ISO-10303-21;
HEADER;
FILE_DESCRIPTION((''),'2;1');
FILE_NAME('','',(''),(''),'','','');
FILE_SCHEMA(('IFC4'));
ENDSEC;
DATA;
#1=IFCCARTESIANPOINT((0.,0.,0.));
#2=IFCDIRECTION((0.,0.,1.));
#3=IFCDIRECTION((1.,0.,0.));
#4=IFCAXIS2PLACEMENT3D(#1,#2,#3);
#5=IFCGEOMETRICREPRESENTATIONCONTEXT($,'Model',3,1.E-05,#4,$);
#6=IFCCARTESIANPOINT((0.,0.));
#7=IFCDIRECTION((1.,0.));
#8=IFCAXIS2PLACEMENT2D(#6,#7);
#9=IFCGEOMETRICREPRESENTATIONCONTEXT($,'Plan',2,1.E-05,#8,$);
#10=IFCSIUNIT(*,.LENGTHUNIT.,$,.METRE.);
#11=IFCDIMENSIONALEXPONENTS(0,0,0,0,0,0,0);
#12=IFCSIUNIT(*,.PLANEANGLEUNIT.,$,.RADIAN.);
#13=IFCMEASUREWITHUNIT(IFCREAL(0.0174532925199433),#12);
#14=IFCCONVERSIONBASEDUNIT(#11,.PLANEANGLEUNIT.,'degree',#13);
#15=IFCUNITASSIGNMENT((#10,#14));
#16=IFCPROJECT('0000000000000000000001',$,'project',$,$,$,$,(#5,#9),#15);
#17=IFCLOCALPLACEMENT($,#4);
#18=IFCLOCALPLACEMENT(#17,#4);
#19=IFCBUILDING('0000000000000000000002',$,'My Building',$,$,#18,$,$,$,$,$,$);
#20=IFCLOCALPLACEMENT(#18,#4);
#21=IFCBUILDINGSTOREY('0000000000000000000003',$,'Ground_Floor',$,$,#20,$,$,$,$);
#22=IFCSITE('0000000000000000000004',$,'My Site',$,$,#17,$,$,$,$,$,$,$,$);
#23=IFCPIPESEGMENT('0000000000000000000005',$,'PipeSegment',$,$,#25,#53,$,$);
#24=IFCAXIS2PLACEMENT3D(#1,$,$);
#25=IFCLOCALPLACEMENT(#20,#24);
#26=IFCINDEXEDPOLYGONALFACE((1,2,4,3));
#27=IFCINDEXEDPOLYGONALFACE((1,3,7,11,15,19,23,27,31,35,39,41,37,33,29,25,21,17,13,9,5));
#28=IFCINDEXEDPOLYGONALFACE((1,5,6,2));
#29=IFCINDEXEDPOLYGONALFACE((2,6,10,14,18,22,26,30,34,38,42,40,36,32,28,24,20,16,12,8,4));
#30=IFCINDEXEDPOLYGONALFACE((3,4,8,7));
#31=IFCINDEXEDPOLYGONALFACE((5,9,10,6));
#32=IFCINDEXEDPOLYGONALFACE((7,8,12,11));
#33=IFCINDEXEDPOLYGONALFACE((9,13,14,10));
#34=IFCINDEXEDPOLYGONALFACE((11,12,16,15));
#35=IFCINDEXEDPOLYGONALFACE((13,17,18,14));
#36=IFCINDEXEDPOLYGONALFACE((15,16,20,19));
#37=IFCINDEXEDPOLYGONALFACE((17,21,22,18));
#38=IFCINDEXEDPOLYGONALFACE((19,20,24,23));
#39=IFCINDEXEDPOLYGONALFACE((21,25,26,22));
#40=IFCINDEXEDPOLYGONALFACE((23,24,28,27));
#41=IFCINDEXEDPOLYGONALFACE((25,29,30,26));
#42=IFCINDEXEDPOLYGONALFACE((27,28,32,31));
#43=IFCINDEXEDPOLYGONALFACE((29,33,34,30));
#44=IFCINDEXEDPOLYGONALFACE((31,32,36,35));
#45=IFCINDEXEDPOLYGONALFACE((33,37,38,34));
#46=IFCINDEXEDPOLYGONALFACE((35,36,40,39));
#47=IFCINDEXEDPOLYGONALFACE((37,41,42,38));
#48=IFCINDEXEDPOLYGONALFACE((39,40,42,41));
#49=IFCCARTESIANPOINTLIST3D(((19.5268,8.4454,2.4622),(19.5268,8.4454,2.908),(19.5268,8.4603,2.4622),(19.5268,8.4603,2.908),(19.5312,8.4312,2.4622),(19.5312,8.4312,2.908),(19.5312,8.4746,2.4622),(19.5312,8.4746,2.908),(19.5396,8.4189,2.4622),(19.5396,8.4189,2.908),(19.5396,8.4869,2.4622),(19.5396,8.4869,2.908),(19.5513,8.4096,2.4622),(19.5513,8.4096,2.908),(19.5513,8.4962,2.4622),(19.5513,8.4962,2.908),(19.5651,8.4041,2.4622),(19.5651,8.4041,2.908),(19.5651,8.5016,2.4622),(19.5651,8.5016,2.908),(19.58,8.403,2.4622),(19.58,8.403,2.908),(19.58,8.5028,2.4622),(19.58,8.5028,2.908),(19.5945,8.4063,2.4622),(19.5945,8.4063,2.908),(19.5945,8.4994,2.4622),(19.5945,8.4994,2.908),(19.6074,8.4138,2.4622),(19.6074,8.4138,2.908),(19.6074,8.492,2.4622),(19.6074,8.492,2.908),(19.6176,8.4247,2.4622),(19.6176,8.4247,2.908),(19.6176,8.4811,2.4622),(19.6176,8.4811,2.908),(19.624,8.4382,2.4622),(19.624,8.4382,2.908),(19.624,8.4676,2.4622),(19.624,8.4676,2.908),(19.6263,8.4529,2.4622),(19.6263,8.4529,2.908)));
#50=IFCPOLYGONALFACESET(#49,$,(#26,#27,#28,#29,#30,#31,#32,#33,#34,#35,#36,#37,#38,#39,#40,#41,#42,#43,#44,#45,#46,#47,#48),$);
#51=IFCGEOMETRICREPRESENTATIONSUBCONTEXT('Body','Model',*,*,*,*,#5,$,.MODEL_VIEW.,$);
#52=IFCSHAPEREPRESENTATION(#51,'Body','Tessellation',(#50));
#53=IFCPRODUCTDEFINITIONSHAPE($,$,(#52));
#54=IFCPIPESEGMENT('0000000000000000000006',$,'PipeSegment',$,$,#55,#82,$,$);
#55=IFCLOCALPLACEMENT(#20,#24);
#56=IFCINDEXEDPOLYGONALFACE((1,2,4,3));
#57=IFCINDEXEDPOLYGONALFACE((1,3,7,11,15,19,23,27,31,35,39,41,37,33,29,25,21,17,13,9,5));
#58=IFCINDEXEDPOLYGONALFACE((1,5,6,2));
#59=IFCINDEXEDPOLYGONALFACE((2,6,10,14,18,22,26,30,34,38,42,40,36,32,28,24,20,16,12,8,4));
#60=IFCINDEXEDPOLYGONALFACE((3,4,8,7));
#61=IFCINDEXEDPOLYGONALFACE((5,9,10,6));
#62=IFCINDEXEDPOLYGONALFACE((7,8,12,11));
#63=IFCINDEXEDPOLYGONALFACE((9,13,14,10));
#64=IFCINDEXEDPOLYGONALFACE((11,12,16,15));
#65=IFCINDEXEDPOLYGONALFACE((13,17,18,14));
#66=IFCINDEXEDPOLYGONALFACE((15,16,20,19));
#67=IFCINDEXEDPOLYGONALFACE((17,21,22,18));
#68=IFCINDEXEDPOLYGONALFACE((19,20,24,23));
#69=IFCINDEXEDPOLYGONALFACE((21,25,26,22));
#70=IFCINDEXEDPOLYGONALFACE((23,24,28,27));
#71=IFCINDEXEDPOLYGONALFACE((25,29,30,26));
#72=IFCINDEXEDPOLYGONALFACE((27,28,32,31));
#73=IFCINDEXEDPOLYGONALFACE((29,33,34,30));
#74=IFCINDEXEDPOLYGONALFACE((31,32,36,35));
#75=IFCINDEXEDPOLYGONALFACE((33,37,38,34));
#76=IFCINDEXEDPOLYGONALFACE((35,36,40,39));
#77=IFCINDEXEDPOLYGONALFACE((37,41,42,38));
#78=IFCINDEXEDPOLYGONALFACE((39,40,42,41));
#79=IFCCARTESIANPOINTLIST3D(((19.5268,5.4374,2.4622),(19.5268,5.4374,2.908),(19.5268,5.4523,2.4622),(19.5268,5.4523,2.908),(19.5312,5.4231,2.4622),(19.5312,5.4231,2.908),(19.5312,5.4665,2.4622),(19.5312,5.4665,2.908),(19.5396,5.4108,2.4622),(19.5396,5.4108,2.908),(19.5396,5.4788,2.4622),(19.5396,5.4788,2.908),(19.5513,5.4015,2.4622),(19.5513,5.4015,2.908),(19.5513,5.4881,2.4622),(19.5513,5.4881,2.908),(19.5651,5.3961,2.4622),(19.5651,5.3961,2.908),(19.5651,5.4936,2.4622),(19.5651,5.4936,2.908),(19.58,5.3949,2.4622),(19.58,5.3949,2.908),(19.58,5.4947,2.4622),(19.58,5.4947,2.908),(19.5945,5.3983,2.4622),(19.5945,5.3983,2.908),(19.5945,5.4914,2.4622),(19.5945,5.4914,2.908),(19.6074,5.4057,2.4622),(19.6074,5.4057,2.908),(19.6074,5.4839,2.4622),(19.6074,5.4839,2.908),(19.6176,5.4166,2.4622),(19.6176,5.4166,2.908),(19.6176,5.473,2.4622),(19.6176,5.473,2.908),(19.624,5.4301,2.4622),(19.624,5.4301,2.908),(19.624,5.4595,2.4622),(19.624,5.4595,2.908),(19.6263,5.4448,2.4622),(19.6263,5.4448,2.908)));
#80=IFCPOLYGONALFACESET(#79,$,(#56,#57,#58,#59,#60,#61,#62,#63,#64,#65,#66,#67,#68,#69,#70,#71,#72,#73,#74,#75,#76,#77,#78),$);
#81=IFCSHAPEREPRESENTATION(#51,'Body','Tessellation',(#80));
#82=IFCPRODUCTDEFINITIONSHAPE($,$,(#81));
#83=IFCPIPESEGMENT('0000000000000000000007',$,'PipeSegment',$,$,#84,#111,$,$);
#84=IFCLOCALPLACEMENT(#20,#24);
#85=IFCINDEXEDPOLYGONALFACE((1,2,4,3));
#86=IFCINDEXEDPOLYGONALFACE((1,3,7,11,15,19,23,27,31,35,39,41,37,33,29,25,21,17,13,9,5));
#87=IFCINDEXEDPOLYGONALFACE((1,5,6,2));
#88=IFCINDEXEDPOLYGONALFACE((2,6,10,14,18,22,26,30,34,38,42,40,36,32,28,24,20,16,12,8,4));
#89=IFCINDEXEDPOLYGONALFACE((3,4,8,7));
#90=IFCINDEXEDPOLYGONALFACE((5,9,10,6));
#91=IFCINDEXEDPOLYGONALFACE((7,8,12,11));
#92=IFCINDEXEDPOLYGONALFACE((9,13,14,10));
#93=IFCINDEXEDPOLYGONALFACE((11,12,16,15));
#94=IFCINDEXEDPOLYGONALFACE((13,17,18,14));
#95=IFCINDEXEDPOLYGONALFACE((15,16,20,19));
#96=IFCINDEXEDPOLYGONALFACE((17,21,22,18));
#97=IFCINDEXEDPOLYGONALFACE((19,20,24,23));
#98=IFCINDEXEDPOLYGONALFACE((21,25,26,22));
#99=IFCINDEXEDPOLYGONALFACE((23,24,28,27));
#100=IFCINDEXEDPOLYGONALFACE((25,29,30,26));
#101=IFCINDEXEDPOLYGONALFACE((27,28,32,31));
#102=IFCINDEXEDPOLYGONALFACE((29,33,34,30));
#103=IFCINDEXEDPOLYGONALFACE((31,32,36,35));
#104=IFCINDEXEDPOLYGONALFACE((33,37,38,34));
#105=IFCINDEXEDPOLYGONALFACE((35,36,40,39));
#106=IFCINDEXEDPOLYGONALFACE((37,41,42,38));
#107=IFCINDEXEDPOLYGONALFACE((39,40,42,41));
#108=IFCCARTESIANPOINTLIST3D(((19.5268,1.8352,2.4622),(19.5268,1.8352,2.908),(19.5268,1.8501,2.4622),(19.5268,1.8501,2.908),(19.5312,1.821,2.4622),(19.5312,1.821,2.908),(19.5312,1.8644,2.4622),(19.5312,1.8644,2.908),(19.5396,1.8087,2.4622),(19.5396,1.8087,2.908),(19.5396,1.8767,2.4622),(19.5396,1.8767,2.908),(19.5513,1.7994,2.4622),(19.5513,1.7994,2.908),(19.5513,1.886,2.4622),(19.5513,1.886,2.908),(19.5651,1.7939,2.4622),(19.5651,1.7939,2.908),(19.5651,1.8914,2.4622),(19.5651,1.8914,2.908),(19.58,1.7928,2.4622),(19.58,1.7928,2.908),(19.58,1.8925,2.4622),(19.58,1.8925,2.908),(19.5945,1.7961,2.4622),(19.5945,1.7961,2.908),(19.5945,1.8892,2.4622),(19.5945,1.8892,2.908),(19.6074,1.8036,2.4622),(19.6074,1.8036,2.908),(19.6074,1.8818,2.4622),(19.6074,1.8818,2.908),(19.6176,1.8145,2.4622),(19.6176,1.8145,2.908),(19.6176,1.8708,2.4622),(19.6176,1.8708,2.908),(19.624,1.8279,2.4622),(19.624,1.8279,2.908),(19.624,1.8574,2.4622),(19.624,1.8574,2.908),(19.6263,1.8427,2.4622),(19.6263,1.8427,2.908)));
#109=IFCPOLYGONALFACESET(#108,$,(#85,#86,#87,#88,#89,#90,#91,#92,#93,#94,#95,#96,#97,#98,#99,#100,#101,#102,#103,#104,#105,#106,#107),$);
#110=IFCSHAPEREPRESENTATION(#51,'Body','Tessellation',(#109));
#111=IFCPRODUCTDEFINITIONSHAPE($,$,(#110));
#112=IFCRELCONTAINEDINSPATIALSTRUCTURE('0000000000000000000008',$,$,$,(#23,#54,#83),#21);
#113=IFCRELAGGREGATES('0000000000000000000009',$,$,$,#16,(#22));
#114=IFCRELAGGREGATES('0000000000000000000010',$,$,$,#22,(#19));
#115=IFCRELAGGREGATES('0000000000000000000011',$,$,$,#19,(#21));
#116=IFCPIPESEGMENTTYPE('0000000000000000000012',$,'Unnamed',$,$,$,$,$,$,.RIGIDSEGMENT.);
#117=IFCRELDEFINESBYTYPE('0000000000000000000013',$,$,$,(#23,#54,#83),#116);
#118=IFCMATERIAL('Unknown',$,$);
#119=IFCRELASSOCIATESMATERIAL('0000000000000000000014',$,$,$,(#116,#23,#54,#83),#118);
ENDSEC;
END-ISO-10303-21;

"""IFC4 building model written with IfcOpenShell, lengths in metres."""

from ifc_helpers import new_model, entity, si_unit, converted_unit, frame, origin_with_axes, origin_2d_with_axis, place, context, subcontext, project, spatial, circle, extrude, material, material_profile, profile_set, profile_usage, type_object, element, save


model = new_model("IFC4")

# Units and contexts
model_context = context("Model", 3, precision=1e-05, world=origin_with_axes())
plan_context = context("Plan", 2, precision=1e-05, world=origin_2d_with_axis())
body_context_1 = subcontext(model_context, "Body", "Model", "MODEL_VIEW")
ifc_project = project(units=[si_unit("LENGTHUNIT", "METRE"), converted_unit("PLANEANGLEUNIT", "degree", entity("IfcReal", 0.0174532925199433), si_unit("PLANEANGLEUNIT", "RADIAN"), dimensions=[0, 0, 0, 0, 0, 0, 0])], contexts=[model_context, plan_context])

# Site, building, storey
site_placement = place(None, origin_with_axes())
site = spatial("IfcSite", under=ifc_project, at=site_placement, Name="My Site")
building_placement = place(site_placement, origin_with_axes())
building = spatial("IfcBuilding", under=site, at=building_placement, Name="My Building")
storey_placement = place(building_placement, origin_with_axes())
storey = spatial("IfcBuildingStorey", under=building, at=storey_placement, Name="Ground_Floor")

# Shared definitions
ifc_material = material(Name="Unknown")

# Pipe segments
ifc_material_profile_1 = material_profile(ifc_material, circle(Radius=0.05))
ifc_profile_set_1 = profile_set([ifc_material_profile_1])
pipe_segment_type = type_object("IfcPipeSegmentType", Name="Unnamed", PredefinedType="RIGIDSEGMENT", material=ifc_profile_set_1)
ifc_profile_usage_1 = profile_usage(ifc_profile_set_1, cardinal=5)
pipe_segment_1_placement = place(storey_placement, frame((19.5763, 8.4529, 2.908), z_axis=(0.0, 0.0, -1.0), x_axis=(1.0, 0.0, 0.0)))
element("IfcPipeSegment", 1, at=pipe_segment_1_placement, inside=storey, type_object=pipe_segment_type, material=ifc_profile_usage_1, Name="PipeSegment", context=body_context_1, shape_type="SweptSolid", body=[
    extrude(circle(Radius=0.05), origin_with_axes(), (0.0, 0.0, 1.0), 0.4458),
])
ifc_profile_usage_2 = profile_usage(ifc_profile_set_1, cardinal=5)
pipe_segment_2_placement = place(storey_placement, frame((19.5763, 5.4448, 2.908), z_axis=(0.0, 0.0, -1.0), x_axis=(1.0, 0.0, 0.0)))
element("IfcPipeSegment", 2, at=pipe_segment_2_placement, inside=storey, type_object=pipe_segment_type, material=ifc_profile_usage_2, Name="PipeSegment", context=body_context_1, shape_type="SweptSolid", body=[
    extrude(circle(Radius=0.05), origin_with_axes(), (0.0, 0.0, 1.0), 0.4458),
])
ifc_profile_usage_3 = profile_usage(ifc_profile_set_1, cardinal=5)
pipe_segment_3_placement = place(storey_placement, frame((19.5763, 1.8427, 2.908), z_axis=(0.0, 0.0, -1.0), x_axis=(1.0, 0.0, 0.0)))
element("IfcPipeSegment", 3, at=pipe_segment_3_placement, inside=storey, type_object=pipe_segment_type, material=ifc_profile_usage_3, Name="PipeSegment", context=body_context_1, shape_type="SweptSolid", body=[
    extrude(circle(Radius=0.05), origin_with_axes(), (0.0, 0.0, 1.0), 0.4458),
])

save(model, "model.ifc")
